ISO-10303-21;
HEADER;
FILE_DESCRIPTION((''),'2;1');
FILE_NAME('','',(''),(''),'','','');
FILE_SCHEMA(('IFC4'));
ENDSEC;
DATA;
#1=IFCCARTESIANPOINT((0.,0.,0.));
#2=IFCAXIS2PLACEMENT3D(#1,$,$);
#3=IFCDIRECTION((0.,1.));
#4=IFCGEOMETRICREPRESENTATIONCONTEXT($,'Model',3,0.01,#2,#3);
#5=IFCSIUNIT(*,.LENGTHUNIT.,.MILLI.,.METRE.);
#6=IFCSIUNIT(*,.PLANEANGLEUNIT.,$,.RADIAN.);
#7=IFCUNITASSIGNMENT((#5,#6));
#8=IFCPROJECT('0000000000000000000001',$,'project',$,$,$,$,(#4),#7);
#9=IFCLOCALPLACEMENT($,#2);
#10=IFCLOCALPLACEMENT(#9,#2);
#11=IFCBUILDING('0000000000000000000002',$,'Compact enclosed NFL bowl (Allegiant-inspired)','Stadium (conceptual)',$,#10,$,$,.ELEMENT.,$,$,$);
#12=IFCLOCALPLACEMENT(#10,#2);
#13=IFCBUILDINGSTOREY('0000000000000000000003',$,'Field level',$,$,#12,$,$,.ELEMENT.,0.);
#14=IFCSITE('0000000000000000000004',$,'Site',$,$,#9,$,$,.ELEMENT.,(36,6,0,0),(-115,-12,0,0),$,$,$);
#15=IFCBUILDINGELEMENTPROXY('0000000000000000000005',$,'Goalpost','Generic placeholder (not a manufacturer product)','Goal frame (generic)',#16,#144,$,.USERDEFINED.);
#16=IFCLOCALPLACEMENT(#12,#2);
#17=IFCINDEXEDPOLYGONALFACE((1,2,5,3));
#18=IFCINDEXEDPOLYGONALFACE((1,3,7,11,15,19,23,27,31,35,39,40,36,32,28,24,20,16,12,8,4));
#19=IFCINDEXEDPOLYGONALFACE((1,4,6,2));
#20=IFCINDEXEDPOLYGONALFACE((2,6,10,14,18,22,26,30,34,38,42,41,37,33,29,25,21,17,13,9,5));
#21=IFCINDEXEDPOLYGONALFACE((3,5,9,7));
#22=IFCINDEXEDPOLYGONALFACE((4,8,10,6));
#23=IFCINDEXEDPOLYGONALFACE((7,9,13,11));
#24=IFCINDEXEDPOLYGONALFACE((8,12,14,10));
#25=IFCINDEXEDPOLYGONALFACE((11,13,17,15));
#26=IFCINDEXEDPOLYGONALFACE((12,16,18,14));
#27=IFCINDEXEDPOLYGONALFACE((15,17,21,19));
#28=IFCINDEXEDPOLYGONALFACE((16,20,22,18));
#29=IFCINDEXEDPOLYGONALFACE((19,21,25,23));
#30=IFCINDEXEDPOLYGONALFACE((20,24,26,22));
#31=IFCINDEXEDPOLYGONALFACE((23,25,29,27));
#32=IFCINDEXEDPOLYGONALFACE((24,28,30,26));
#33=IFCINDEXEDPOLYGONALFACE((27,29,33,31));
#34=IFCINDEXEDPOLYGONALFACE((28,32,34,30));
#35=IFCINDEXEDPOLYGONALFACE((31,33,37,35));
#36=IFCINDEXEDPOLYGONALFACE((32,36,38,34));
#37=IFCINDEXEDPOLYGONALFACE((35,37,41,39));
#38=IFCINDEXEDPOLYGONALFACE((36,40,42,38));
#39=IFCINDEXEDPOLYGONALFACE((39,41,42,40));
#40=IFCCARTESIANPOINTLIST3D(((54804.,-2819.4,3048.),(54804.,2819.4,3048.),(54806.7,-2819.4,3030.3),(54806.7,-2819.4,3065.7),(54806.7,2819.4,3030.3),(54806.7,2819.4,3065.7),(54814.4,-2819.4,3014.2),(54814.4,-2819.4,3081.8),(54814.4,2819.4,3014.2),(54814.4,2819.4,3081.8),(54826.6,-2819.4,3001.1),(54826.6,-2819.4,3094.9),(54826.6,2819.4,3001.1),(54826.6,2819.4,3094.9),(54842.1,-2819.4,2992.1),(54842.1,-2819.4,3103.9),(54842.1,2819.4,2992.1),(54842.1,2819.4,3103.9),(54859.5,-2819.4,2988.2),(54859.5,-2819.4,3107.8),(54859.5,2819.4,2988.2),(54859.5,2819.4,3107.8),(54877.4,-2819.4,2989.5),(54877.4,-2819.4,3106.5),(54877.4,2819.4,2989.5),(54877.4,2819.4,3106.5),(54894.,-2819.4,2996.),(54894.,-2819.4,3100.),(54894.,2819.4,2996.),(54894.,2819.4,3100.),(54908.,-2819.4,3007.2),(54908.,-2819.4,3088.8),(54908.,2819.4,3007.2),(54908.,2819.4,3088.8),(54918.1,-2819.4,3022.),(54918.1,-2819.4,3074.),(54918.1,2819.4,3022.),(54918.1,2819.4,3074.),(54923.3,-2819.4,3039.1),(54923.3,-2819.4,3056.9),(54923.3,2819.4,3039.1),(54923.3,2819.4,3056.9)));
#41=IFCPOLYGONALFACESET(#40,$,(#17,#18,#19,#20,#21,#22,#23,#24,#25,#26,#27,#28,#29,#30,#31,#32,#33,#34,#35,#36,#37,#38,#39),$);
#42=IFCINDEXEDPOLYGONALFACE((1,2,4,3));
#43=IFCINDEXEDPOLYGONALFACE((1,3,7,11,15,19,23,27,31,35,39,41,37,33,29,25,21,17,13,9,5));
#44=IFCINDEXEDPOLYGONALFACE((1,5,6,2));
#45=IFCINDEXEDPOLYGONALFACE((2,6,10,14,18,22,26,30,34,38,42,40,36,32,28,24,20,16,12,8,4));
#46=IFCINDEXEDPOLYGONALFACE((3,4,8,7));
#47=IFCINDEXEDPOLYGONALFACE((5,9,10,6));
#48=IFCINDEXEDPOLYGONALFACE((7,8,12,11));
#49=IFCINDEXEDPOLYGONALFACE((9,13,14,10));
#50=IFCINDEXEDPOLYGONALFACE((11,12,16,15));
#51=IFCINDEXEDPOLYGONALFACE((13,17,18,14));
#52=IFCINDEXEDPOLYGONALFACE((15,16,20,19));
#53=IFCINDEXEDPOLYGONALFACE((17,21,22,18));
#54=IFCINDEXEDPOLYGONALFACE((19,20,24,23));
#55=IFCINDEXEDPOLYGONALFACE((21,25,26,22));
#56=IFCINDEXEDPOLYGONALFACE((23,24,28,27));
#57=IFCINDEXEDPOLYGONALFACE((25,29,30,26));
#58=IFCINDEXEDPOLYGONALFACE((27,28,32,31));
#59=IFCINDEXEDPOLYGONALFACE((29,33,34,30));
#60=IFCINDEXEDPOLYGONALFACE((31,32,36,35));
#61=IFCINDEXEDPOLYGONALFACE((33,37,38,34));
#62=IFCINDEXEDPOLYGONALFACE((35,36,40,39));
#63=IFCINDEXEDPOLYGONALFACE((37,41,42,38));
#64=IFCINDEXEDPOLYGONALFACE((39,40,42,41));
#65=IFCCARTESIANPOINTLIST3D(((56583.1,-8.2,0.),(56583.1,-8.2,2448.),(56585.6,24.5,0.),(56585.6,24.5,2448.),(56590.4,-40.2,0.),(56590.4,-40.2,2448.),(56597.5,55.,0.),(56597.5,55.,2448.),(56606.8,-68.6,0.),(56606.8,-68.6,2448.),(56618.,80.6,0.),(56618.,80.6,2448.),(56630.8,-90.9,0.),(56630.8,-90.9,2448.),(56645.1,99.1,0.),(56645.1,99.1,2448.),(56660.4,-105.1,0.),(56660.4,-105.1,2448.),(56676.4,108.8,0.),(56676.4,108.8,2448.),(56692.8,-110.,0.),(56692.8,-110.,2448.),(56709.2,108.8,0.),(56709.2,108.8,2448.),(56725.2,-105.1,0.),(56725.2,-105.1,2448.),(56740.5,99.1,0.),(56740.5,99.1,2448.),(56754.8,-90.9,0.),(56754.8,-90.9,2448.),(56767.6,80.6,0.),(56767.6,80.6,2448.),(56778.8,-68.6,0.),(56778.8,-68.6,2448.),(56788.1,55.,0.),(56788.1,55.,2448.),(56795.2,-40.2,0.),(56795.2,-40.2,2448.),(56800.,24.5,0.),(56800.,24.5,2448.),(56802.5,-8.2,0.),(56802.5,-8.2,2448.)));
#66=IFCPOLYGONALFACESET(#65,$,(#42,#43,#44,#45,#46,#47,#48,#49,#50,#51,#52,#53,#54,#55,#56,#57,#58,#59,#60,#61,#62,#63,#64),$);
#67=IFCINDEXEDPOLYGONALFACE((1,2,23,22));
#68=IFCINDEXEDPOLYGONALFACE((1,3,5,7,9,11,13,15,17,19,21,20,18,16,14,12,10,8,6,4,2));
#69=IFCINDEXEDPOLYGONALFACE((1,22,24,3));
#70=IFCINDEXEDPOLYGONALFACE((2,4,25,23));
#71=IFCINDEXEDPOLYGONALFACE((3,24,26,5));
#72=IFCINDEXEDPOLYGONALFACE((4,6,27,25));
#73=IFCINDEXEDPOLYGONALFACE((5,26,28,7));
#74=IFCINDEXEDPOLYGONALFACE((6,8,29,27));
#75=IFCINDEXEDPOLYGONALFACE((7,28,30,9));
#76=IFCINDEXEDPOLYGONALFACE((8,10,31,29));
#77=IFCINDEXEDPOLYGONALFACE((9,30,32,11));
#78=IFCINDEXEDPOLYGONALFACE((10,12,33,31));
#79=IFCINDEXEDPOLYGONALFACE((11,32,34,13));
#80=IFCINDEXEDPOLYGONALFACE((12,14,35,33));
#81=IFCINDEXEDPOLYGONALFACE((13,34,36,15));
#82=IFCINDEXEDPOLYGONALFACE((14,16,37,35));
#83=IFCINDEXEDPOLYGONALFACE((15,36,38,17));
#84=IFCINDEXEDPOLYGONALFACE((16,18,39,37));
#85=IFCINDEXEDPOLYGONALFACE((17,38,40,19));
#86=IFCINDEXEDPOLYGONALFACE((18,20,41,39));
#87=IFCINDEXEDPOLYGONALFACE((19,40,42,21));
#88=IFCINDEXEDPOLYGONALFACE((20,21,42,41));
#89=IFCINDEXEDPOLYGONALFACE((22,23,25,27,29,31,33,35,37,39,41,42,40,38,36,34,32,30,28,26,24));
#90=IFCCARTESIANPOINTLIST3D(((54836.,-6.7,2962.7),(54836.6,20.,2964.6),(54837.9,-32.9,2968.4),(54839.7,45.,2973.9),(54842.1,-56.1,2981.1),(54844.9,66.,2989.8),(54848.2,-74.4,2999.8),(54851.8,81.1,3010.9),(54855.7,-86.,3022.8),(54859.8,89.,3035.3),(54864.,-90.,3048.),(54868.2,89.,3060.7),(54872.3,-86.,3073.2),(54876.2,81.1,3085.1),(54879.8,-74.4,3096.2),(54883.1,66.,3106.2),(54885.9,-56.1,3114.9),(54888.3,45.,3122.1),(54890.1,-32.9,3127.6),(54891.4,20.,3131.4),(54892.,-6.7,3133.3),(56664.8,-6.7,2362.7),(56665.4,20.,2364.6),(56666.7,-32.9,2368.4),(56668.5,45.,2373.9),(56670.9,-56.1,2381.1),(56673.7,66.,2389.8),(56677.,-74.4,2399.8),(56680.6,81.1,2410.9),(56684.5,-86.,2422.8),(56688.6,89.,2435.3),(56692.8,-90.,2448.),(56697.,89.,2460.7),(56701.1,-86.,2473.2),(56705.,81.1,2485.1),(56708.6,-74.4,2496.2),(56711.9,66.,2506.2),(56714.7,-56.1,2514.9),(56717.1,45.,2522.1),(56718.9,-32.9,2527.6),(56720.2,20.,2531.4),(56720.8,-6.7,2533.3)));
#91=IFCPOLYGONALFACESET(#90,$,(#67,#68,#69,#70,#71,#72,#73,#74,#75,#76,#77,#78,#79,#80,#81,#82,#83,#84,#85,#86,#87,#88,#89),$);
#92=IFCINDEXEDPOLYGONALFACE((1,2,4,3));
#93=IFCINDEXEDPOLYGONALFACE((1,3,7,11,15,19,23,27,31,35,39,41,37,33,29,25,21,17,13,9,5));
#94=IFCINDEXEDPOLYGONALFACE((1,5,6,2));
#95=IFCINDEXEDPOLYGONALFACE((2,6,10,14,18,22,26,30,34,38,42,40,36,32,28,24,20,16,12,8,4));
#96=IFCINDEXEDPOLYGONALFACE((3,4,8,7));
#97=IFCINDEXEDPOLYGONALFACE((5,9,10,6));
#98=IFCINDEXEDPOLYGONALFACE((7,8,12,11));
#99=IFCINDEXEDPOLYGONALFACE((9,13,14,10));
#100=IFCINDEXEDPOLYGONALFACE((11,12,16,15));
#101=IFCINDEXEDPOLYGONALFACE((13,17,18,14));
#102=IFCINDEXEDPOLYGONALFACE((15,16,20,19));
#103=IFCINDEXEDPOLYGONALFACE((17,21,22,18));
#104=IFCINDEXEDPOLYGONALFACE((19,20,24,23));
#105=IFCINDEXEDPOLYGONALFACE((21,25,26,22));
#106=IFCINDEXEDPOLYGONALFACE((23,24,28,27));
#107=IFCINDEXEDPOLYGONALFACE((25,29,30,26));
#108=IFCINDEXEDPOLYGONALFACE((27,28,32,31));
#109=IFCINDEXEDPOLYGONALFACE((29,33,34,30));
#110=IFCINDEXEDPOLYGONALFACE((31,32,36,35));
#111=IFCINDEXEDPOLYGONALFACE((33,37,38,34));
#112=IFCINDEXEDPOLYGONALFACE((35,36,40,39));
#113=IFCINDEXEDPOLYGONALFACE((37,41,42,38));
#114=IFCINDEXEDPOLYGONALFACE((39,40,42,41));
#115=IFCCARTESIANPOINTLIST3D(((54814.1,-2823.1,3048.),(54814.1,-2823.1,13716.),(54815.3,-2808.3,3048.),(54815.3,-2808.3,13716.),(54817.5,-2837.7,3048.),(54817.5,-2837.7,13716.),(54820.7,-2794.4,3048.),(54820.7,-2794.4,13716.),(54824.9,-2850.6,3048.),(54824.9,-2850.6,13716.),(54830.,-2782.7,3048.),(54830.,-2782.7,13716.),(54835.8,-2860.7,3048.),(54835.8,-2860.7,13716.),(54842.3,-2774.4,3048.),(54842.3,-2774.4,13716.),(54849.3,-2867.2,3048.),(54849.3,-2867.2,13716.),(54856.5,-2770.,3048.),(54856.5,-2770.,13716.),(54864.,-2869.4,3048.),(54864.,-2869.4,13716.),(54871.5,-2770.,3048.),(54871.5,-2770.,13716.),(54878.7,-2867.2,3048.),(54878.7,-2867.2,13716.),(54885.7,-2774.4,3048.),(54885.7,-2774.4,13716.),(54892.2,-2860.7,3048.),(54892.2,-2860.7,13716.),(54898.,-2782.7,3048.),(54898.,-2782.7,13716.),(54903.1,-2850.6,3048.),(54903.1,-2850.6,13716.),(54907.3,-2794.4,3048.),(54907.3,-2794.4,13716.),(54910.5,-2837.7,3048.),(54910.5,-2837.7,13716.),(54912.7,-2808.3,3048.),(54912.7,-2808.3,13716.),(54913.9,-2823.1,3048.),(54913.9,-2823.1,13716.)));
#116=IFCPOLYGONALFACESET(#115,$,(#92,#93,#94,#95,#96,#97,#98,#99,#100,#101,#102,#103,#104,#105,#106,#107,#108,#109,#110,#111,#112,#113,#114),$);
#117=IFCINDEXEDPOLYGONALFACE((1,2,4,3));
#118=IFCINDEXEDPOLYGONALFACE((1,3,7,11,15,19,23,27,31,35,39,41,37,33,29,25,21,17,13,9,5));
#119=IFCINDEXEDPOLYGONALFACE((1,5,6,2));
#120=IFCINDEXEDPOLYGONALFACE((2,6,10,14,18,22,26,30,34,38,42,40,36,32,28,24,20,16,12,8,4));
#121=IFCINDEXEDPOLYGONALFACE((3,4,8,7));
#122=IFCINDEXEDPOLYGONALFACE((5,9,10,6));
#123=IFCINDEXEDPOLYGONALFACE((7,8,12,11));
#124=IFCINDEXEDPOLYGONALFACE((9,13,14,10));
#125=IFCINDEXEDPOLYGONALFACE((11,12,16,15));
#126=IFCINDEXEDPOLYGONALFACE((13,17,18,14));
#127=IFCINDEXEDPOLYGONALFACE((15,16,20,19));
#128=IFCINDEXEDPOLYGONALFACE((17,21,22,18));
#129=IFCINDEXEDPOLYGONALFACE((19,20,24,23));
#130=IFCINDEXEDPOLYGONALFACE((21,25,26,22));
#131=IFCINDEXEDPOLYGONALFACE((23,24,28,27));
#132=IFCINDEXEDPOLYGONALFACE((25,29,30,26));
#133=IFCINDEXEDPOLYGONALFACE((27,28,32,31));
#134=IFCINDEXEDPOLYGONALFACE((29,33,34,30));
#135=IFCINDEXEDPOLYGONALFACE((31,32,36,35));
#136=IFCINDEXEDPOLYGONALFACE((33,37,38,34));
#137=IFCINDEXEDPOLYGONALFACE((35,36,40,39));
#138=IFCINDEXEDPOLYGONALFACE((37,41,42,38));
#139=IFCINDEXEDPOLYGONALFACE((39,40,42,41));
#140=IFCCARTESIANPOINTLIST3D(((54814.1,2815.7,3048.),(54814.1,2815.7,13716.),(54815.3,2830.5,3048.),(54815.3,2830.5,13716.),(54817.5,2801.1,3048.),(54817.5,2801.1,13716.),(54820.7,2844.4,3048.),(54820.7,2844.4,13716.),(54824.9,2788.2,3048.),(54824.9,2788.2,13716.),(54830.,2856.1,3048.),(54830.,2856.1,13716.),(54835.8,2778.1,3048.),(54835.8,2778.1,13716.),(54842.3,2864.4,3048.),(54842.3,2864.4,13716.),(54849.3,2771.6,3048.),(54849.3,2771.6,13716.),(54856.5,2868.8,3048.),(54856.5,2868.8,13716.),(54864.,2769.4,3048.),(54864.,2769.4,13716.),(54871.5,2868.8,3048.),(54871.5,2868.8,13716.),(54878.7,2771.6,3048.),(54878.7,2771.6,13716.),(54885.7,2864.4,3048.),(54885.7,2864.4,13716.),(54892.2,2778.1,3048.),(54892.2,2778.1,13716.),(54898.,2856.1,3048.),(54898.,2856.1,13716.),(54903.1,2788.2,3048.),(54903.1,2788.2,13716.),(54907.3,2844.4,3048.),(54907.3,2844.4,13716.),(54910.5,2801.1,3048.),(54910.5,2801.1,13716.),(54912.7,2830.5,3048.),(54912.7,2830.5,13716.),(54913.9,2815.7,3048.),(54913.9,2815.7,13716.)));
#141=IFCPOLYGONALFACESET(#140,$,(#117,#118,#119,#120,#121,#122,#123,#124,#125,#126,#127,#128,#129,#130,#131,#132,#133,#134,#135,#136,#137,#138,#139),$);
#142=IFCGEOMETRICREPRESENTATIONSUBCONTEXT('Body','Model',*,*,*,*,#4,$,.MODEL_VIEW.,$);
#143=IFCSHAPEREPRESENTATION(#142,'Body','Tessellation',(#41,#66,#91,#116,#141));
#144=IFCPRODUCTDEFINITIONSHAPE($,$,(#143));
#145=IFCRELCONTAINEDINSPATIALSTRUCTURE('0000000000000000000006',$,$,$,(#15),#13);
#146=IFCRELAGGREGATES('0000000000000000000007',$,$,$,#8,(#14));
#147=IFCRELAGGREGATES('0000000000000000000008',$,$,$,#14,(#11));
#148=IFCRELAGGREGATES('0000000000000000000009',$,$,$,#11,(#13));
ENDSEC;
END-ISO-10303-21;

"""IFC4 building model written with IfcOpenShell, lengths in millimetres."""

from ifc_helpers import new_model, si_unit, direction, frame, origin, place, context, subcontext, project, spatial, circle, extrude, element, save


model = new_model("IFC4")

# Units and contexts
model_context = context("Model", 3, precision=0.01, world=origin(), true_north=direction((0.0, 1.0)))
body_context = subcontext(model_context, "Body", "Model", "MODEL_VIEW")
ifc_project = project(units=[si_unit("LENGTHUNIT", "METRE", prefix="MILLI"), si_unit("PLANEANGLEUNIT", "RADIAN")], contexts=[model_context])

# Site, building, storey
site_placement = place(None, origin())
site = spatial("IfcSite", under=ifc_project, at=site_placement, Name="Site", CompositionType="ELEMENT", RefLatitude=(36, 6, 0, 0), RefLongitude=(-115, -12, 0, 0))
building_placement = place(site_placement, origin())
building = spatial("IfcBuilding", under=site, at=building_placement, Name="Compact enclosed NFL bowl (Allegiant-inspired)", Description="Stadium (conceptual)", CompositionType="ELEMENT")
storey_placement = place(building_placement, origin())
storey = spatial("IfcBuildingStorey", under=building, at=storey_placement, Name="Field level", CompositionType="ELEMENT", Elevation=0.0)

# Shared definitions
placement = place(storey_placement, origin())

# Building element proxy
element("IfcBuildingElementProxy", 1, at=placement, inside=storey, Name="Goalpost", Description="Generic placeholder (not a manufacturer product)", ObjectType="Goal frame (generic)", PredefinedType="USERDEFINED", context=body_context, shape_type="SweptSolid", body=[
    extrude(circle(Radius=60.0), frame((54864.0, -2819.4, 3048.0), z_axis=(0.0, 1.0, 0.0), x_axis=(-1.0, 0.0, 0.0)), (0.0, 0.0, 1.0), 5638.8),
    extrude(circle(Radius=110.0), frame((56692.8, 0.0, 0.0), z_axis=(0.0, 0.0, 1.0), x_axis=(0.0, -1.0, 0.0)), (0.0, 0.0, 1.0), 2448.0),
    extrude(circle(Radius=90.0), frame((56692.8, 0.0, 2448.0), z_axis=(-0.950169, 0.0, 0.311735), x_axis=(0.0, -1.0, 0.0)), (0.0, 0.0, 1.0), 1924.7),
    extrude(circle(Radius=50.0), frame((54864.0, -2819.4, 3048.0), z_axis=(0.0, 0.0, 1.0), x_axis=(0.0, -1.0, 0.0)), (0.0, 0.0, 1.0), 10668.0),
    extrude(circle(Radius=50.0), frame((54864.0, 2819.4, 3048.0), z_axis=(0.0, 0.0, 1.0), x_axis=(0.0, -1.0, 0.0)), (0.0, 0.0, 1.0), 10668.0),
])

save(model, "model.ifc")
